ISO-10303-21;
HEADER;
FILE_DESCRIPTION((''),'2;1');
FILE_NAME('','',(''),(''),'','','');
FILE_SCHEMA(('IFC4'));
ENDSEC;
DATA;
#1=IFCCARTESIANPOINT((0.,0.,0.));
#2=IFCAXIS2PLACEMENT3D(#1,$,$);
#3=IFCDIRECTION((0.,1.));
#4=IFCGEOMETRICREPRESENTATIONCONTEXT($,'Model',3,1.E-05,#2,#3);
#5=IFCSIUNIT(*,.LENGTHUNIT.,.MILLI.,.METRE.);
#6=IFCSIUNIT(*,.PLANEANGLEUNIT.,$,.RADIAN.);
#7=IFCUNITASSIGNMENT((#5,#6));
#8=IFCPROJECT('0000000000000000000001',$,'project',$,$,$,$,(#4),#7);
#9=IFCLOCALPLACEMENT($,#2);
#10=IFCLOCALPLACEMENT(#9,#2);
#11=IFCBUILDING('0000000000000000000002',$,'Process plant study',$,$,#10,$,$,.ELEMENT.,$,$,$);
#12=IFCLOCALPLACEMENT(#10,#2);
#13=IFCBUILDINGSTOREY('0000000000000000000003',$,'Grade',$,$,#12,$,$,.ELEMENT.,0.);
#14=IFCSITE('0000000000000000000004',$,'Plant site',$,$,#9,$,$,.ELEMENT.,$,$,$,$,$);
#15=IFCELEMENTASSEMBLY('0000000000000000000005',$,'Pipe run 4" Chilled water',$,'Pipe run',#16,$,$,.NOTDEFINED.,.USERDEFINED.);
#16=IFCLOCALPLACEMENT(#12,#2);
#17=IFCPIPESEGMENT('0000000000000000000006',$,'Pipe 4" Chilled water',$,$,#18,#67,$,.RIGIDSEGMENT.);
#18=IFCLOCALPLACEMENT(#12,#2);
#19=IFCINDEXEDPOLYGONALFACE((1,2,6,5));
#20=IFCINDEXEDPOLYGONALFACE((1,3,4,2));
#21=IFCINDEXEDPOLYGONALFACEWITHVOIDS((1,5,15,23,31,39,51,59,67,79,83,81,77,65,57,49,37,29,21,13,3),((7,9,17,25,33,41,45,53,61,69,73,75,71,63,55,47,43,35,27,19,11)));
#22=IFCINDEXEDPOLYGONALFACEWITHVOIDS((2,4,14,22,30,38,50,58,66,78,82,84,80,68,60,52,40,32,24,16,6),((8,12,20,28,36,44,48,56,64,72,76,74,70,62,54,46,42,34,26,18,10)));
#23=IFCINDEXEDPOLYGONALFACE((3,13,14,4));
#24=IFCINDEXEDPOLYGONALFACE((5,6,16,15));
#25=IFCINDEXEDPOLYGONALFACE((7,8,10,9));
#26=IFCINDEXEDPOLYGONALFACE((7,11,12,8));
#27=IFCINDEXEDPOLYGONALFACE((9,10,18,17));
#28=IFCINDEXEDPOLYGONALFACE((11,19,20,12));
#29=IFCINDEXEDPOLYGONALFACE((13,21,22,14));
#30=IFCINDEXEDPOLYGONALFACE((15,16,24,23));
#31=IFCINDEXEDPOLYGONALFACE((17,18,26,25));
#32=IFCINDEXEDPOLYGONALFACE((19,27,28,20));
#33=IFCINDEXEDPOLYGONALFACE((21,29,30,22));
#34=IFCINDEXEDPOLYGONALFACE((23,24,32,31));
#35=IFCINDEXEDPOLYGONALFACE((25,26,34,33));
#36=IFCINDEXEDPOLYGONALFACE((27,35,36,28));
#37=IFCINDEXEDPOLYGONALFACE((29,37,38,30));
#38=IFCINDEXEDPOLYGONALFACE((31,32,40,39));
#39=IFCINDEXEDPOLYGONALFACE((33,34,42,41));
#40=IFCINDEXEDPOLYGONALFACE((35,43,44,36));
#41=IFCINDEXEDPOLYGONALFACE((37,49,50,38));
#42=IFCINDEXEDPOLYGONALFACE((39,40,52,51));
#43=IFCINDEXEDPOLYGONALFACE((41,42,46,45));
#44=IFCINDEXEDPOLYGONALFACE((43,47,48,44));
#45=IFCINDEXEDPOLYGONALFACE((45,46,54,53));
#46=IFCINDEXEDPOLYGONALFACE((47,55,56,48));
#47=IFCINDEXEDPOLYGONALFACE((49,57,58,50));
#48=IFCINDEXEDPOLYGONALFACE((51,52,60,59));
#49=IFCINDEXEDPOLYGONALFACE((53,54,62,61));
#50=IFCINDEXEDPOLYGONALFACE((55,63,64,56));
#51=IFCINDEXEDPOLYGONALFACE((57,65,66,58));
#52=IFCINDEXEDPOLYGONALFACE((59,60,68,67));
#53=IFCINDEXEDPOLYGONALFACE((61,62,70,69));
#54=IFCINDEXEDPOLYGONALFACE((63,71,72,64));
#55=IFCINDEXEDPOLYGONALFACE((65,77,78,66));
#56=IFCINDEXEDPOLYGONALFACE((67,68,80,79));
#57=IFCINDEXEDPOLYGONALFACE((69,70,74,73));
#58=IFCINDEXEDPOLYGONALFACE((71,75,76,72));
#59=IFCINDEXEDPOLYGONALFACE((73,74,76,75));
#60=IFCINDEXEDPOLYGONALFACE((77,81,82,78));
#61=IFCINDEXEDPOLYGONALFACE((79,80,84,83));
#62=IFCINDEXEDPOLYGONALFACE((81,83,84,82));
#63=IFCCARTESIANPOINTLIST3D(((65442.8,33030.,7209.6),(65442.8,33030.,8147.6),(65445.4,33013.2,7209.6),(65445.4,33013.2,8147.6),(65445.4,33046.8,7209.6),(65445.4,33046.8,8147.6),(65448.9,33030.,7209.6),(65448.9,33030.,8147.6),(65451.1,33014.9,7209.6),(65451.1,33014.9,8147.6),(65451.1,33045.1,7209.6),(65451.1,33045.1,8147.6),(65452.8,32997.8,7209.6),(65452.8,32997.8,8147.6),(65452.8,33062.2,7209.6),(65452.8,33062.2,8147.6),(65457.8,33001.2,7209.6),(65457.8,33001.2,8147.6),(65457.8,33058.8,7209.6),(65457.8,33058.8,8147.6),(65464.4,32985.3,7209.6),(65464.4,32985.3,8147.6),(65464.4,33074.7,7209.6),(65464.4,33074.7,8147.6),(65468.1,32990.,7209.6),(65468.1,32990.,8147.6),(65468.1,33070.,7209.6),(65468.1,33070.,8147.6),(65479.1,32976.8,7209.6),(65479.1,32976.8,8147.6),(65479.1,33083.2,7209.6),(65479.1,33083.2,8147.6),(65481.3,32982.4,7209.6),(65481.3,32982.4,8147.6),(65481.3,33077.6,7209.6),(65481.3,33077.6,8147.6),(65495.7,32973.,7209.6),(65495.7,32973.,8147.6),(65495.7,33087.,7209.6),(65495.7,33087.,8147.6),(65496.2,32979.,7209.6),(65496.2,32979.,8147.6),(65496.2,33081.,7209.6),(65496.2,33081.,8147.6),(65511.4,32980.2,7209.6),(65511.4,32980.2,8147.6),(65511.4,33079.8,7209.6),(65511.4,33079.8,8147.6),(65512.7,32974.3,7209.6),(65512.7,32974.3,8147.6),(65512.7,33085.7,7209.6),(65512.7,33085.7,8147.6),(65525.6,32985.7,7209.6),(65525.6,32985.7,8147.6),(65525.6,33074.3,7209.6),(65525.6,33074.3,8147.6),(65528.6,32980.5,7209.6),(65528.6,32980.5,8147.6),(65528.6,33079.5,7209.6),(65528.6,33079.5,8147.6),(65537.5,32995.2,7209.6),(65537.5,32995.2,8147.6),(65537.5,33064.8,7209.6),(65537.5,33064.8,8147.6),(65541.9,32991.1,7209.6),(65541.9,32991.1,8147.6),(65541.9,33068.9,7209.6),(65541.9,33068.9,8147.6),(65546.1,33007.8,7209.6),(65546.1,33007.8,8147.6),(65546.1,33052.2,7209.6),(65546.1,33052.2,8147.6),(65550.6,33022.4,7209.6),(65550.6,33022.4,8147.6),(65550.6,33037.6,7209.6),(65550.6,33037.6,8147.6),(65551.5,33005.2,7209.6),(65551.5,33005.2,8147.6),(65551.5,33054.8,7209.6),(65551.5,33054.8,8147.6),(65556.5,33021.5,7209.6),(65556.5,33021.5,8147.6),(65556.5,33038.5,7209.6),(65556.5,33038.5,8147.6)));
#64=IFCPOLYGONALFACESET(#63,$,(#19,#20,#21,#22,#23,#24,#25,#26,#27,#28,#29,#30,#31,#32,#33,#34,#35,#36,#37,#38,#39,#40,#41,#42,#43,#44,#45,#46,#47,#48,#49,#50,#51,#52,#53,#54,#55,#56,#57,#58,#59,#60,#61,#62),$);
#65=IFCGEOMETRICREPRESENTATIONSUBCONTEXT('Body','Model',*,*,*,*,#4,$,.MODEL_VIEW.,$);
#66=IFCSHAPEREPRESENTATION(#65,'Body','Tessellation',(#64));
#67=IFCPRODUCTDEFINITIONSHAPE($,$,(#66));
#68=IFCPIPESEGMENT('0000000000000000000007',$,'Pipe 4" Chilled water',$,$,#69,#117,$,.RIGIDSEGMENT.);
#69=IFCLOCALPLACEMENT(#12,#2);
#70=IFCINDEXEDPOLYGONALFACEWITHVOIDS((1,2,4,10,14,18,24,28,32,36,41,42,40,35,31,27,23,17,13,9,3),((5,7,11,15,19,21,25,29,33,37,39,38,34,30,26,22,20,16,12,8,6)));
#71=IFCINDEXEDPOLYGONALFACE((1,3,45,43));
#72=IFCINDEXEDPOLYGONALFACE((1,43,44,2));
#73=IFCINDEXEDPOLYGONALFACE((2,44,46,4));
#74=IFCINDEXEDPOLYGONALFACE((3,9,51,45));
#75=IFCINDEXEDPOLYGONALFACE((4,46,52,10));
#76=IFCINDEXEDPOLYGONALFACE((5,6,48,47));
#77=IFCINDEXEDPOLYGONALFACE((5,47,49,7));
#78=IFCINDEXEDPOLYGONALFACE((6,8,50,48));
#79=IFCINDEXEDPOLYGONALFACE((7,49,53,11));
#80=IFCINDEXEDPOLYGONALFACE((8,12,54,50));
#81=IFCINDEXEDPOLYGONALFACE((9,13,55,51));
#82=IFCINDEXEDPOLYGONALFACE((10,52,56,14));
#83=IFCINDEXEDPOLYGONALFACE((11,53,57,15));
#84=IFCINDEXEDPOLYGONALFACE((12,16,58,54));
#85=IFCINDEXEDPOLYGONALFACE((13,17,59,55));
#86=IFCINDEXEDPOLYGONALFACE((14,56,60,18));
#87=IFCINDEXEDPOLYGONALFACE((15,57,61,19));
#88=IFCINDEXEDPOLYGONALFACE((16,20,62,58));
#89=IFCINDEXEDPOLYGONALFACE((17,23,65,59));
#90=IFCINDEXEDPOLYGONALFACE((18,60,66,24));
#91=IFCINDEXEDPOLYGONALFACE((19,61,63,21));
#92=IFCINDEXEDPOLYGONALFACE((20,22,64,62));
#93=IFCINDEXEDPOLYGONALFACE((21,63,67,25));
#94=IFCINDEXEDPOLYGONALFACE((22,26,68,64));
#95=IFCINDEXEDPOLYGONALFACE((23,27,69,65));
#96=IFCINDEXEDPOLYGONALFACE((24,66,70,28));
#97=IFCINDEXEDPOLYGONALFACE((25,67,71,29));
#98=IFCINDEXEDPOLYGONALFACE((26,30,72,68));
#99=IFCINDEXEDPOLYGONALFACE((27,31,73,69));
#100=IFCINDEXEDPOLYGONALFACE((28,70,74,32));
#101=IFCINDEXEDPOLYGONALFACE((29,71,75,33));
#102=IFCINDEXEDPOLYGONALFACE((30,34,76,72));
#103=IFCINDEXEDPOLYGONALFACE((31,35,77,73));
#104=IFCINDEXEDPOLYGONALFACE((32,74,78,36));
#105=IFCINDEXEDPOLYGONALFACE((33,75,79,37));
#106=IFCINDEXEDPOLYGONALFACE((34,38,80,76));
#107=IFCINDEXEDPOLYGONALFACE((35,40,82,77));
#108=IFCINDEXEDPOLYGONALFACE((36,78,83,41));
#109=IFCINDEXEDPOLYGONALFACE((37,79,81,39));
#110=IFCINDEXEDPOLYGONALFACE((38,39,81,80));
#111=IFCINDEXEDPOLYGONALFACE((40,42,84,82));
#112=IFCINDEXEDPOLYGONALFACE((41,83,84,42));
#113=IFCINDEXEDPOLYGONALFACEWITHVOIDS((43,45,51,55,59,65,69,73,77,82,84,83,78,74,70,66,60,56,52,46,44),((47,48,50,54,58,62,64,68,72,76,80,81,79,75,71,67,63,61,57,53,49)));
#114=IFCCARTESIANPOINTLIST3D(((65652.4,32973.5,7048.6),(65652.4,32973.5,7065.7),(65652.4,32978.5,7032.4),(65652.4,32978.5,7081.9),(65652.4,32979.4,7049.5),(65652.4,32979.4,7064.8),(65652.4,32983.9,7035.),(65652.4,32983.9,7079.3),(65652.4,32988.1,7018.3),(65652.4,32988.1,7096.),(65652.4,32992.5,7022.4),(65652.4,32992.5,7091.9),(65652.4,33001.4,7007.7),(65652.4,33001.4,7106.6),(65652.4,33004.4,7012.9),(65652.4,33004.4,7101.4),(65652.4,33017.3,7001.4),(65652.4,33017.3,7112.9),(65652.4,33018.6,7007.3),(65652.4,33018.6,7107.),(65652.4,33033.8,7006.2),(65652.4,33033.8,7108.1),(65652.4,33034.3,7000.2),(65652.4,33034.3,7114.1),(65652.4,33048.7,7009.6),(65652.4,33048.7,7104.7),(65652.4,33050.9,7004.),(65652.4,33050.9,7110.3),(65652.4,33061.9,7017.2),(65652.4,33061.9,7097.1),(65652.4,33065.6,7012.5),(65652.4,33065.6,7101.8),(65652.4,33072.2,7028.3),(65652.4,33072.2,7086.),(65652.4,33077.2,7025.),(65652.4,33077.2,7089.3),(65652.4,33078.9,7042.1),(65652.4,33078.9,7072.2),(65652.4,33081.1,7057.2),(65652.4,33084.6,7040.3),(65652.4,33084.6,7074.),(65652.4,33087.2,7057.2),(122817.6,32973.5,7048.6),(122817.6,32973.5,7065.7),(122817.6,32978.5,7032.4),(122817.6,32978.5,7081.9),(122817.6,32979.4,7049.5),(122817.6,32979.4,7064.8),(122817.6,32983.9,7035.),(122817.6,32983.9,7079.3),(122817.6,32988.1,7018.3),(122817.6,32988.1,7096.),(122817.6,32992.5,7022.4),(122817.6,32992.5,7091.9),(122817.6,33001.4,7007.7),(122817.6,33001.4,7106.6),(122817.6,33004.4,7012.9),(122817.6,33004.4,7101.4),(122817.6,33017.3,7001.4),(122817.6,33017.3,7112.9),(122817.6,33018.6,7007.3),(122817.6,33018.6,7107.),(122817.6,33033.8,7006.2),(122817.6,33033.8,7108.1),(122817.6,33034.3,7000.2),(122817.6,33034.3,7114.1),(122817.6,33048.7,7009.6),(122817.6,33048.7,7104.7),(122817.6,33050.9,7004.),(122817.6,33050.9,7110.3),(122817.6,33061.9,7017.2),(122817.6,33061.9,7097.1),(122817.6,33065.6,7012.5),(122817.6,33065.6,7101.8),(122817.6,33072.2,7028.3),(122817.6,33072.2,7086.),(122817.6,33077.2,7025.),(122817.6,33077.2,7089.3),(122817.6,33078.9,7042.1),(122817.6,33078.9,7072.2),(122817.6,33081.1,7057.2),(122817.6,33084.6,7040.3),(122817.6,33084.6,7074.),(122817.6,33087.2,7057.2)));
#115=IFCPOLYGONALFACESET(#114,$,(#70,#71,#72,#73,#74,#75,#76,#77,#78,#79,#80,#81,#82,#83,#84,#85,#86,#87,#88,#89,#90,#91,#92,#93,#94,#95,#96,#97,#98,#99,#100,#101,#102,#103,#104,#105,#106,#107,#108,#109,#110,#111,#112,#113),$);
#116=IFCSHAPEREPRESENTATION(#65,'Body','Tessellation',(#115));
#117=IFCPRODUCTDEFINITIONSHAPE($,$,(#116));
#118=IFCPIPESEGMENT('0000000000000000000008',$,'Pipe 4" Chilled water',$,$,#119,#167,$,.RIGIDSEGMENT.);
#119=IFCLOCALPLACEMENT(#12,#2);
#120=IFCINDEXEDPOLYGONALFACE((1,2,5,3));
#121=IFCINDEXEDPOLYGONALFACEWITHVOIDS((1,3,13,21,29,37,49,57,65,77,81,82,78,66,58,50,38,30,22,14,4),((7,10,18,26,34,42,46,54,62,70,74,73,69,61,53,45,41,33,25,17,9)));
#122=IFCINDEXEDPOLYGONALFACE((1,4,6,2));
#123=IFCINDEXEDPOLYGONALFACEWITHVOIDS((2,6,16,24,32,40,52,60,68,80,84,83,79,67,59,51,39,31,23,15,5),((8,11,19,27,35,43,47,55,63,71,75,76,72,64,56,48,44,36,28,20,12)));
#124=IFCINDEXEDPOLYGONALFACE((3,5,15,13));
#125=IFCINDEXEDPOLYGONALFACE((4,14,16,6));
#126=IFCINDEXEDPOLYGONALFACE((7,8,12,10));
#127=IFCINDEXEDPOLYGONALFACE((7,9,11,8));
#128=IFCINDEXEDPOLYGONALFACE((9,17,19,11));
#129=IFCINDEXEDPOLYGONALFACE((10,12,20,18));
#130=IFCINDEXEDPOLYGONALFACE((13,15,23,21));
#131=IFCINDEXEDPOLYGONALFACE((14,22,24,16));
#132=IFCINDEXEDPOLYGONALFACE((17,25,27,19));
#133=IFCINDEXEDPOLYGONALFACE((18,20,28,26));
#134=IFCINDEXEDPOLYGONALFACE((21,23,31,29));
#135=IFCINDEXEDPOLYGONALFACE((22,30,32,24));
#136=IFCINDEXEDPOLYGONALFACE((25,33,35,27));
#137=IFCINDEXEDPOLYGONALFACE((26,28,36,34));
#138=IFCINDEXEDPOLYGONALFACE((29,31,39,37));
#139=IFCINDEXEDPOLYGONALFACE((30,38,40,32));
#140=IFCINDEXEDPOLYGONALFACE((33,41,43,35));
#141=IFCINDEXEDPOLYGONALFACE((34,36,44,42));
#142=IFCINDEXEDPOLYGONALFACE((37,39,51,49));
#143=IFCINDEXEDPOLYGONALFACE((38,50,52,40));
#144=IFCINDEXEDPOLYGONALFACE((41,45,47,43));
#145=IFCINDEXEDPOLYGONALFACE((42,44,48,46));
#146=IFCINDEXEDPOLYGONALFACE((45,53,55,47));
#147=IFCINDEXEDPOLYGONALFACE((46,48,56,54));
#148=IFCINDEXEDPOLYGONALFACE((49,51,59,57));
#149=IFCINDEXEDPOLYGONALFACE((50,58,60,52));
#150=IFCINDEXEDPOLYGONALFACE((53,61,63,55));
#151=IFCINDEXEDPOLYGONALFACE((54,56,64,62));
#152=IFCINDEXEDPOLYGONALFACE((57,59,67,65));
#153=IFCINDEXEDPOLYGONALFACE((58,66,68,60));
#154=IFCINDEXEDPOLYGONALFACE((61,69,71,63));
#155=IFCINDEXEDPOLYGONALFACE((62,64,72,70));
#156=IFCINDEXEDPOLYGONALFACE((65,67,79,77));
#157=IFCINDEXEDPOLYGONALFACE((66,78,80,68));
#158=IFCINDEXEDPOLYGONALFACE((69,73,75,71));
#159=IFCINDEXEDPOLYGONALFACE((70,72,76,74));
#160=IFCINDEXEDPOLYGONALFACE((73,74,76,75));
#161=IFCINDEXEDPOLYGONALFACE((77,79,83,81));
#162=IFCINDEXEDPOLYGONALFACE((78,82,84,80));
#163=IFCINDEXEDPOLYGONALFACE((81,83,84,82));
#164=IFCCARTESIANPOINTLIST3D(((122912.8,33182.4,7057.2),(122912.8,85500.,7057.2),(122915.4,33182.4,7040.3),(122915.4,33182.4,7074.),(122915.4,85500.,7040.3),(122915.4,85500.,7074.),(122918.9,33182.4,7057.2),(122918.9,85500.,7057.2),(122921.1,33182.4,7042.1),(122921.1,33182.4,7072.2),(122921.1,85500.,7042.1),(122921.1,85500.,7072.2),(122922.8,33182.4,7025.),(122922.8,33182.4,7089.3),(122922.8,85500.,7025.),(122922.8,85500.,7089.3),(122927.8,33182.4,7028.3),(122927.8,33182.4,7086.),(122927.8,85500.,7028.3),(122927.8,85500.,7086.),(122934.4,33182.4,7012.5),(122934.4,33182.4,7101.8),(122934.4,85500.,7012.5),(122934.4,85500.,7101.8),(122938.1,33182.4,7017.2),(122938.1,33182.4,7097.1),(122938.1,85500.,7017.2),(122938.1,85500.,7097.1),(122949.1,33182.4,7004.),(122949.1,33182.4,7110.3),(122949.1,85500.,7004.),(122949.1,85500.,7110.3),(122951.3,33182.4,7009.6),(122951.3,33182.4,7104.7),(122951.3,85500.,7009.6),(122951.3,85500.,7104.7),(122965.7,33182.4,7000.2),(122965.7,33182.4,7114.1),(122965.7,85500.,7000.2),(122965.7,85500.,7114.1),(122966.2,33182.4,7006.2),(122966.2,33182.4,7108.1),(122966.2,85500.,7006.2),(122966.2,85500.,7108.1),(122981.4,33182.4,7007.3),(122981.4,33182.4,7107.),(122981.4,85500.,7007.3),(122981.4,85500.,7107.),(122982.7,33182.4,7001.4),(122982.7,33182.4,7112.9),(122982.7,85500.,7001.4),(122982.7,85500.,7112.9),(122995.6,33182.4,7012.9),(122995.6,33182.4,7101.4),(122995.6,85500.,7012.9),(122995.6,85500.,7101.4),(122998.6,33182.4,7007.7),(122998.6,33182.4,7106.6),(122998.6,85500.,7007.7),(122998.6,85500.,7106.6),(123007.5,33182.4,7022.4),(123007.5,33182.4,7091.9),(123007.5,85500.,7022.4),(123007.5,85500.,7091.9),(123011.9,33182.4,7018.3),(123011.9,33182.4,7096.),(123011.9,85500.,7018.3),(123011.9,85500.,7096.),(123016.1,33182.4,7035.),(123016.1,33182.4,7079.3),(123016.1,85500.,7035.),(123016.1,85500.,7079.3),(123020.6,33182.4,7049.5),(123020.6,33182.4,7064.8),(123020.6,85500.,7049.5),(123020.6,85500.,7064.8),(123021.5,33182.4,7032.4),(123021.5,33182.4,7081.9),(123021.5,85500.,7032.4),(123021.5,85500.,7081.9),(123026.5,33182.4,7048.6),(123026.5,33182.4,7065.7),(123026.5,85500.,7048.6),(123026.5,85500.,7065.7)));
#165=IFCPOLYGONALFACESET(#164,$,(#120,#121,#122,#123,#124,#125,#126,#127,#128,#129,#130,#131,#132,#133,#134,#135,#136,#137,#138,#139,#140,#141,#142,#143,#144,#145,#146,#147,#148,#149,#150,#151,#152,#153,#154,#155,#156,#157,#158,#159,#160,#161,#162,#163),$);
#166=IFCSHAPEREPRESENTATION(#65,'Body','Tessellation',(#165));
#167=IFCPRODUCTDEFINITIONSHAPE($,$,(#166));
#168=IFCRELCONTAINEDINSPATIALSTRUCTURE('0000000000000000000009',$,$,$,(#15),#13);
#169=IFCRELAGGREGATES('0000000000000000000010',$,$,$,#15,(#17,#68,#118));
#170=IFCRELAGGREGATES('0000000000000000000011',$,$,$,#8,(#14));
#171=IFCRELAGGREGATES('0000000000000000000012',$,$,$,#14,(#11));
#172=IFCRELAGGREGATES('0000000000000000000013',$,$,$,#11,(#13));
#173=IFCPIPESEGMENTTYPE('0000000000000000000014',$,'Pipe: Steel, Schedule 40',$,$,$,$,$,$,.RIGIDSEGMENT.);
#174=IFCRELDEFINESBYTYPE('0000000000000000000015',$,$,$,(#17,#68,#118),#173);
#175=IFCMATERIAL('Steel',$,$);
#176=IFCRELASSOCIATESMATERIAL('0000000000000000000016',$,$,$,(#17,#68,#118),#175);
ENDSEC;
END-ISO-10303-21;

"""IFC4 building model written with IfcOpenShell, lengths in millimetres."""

from ifc_helpers import new_model, si_unit, direction, frame, origin, origin_with_axes, origin_2d, place, context, subcontext, project, spatial, hollow_circle, extrude, material, type_object, element, aggregate, save


model = new_model("IFC4")

# Units and contexts
model_context = context("Model", 3, precision=1e-05, world=origin(), true_north=direction((0.0, 1.0)))
body_context = subcontext(model_context, "Body", "Model", "MODEL_VIEW")
ifc_project = project(units=[si_unit("LENGTHUNIT", "METRE", prefix="MILLI"), si_unit("PLANEANGLEUNIT", "RADIAN")], contexts=[model_context])

# Site, building, storey
site_placement = place(None, origin())
site = spatial("IfcSite", under=ifc_project, at=site_placement, Name="Plant site", CompositionType="ELEMENT")
building_placement = place(site_placement, origin())
building = spatial("IfcBuilding", under=site, at=building_placement, Name="Process plant study", CompositionType="ELEMENT")
storey_placement = place(building_placement, origin())
storey = spatial("IfcBuildingStorey", under=building, at=storey_placement, Name="Grade", CompositionType="ELEMENT", Elevation=0.0)

# Shared definitions
ifc_material = material(Name="Steel")
pipe_segment_type = type_object("IfcPipeSegmentType", Name="Pipe: Steel, Schedule 40", PredefinedType="RIGIDSEGMENT")

# Element assembly, pipe segments
assembly_1_placement = place(storey_placement, origin_with_axes())
assembly_1 = element("IfcElementAssembly", 1, at=assembly_1_placement, inside=storey, Name="Pipe run 4\" Chilled water", ObjectType="Pipe run", AssemblyPlace="NOTDEFINED", PredefinedType="USERDEFINED")
pipe_segment_1_placement = place(storey_placement, origin_with_axes())
pipe_segment_1 = element("IfcPipeSegment", 2, at=pipe_segment_1_placement, type_object=pipe_segment_type, material=ifc_material, Name="Pipe 4\" Chilled water", PredefinedType="RIGIDSEGMENT", context=body_context, shape_type="SweptSolid", body=[
    extrude(hollow_circle(Radius=57.1, WallThickness=6.0, at=origin_2d()), frame((65500.0, 33030.0, 8147.6), z_axis=(0.0, 0.0, -1.0), x_axis=(-1.0, 0.0, 0.0)), (0.0, 0.0, 1.0), 938.0),
])
pipe_segment_2_placement = place(storey_placement, origin_with_axes())
pipe_segment_2 = element("IfcPipeSegment", 3, at=pipe_segment_2_placement, type_object=pipe_segment_type, material=ifc_material, Name="Pipe 4\" Chilled water", PredefinedType="RIGIDSEGMENT", context=body_context, shape_type="SweptSolid", body=[
    extrude(hollow_circle(Radius=57.1, WallThickness=6.0, at=origin_2d()), frame((65652.4, 33030.0, 7057.1), z_axis=(1.0, 0.0, 0.0), x_axis=(0.0, 1.0, 0.0)), (0.0, 0.0, 1.0), 57165.2),
])
pipe_segment_3_placement = place(storey_placement, origin_with_axes())
pipe_segment_3 = element("IfcPipeSegment", 4, at=pipe_segment_3_placement, type_object=pipe_segment_type, material=ifc_material, Name="Pipe 4\" Chilled water", PredefinedType="RIGIDSEGMENT", context=body_context, shape_type="SweptSolid", body=[
    extrude(hollow_circle(Radius=57.1, WallThickness=6.0, at=origin_2d()), frame((122970.0, 33182.4, 7057.1), z_axis=(0.0, 1.0, 0.0), x_axis=(-1.0, 0.0, 0.0)), (0.0, 0.0, 1.0), 52317.6),
])

aggregate(assembly_1, [pipe_segment_1, pipe_segment_2, pipe_segment_3])

save(model, "model.ifc")
